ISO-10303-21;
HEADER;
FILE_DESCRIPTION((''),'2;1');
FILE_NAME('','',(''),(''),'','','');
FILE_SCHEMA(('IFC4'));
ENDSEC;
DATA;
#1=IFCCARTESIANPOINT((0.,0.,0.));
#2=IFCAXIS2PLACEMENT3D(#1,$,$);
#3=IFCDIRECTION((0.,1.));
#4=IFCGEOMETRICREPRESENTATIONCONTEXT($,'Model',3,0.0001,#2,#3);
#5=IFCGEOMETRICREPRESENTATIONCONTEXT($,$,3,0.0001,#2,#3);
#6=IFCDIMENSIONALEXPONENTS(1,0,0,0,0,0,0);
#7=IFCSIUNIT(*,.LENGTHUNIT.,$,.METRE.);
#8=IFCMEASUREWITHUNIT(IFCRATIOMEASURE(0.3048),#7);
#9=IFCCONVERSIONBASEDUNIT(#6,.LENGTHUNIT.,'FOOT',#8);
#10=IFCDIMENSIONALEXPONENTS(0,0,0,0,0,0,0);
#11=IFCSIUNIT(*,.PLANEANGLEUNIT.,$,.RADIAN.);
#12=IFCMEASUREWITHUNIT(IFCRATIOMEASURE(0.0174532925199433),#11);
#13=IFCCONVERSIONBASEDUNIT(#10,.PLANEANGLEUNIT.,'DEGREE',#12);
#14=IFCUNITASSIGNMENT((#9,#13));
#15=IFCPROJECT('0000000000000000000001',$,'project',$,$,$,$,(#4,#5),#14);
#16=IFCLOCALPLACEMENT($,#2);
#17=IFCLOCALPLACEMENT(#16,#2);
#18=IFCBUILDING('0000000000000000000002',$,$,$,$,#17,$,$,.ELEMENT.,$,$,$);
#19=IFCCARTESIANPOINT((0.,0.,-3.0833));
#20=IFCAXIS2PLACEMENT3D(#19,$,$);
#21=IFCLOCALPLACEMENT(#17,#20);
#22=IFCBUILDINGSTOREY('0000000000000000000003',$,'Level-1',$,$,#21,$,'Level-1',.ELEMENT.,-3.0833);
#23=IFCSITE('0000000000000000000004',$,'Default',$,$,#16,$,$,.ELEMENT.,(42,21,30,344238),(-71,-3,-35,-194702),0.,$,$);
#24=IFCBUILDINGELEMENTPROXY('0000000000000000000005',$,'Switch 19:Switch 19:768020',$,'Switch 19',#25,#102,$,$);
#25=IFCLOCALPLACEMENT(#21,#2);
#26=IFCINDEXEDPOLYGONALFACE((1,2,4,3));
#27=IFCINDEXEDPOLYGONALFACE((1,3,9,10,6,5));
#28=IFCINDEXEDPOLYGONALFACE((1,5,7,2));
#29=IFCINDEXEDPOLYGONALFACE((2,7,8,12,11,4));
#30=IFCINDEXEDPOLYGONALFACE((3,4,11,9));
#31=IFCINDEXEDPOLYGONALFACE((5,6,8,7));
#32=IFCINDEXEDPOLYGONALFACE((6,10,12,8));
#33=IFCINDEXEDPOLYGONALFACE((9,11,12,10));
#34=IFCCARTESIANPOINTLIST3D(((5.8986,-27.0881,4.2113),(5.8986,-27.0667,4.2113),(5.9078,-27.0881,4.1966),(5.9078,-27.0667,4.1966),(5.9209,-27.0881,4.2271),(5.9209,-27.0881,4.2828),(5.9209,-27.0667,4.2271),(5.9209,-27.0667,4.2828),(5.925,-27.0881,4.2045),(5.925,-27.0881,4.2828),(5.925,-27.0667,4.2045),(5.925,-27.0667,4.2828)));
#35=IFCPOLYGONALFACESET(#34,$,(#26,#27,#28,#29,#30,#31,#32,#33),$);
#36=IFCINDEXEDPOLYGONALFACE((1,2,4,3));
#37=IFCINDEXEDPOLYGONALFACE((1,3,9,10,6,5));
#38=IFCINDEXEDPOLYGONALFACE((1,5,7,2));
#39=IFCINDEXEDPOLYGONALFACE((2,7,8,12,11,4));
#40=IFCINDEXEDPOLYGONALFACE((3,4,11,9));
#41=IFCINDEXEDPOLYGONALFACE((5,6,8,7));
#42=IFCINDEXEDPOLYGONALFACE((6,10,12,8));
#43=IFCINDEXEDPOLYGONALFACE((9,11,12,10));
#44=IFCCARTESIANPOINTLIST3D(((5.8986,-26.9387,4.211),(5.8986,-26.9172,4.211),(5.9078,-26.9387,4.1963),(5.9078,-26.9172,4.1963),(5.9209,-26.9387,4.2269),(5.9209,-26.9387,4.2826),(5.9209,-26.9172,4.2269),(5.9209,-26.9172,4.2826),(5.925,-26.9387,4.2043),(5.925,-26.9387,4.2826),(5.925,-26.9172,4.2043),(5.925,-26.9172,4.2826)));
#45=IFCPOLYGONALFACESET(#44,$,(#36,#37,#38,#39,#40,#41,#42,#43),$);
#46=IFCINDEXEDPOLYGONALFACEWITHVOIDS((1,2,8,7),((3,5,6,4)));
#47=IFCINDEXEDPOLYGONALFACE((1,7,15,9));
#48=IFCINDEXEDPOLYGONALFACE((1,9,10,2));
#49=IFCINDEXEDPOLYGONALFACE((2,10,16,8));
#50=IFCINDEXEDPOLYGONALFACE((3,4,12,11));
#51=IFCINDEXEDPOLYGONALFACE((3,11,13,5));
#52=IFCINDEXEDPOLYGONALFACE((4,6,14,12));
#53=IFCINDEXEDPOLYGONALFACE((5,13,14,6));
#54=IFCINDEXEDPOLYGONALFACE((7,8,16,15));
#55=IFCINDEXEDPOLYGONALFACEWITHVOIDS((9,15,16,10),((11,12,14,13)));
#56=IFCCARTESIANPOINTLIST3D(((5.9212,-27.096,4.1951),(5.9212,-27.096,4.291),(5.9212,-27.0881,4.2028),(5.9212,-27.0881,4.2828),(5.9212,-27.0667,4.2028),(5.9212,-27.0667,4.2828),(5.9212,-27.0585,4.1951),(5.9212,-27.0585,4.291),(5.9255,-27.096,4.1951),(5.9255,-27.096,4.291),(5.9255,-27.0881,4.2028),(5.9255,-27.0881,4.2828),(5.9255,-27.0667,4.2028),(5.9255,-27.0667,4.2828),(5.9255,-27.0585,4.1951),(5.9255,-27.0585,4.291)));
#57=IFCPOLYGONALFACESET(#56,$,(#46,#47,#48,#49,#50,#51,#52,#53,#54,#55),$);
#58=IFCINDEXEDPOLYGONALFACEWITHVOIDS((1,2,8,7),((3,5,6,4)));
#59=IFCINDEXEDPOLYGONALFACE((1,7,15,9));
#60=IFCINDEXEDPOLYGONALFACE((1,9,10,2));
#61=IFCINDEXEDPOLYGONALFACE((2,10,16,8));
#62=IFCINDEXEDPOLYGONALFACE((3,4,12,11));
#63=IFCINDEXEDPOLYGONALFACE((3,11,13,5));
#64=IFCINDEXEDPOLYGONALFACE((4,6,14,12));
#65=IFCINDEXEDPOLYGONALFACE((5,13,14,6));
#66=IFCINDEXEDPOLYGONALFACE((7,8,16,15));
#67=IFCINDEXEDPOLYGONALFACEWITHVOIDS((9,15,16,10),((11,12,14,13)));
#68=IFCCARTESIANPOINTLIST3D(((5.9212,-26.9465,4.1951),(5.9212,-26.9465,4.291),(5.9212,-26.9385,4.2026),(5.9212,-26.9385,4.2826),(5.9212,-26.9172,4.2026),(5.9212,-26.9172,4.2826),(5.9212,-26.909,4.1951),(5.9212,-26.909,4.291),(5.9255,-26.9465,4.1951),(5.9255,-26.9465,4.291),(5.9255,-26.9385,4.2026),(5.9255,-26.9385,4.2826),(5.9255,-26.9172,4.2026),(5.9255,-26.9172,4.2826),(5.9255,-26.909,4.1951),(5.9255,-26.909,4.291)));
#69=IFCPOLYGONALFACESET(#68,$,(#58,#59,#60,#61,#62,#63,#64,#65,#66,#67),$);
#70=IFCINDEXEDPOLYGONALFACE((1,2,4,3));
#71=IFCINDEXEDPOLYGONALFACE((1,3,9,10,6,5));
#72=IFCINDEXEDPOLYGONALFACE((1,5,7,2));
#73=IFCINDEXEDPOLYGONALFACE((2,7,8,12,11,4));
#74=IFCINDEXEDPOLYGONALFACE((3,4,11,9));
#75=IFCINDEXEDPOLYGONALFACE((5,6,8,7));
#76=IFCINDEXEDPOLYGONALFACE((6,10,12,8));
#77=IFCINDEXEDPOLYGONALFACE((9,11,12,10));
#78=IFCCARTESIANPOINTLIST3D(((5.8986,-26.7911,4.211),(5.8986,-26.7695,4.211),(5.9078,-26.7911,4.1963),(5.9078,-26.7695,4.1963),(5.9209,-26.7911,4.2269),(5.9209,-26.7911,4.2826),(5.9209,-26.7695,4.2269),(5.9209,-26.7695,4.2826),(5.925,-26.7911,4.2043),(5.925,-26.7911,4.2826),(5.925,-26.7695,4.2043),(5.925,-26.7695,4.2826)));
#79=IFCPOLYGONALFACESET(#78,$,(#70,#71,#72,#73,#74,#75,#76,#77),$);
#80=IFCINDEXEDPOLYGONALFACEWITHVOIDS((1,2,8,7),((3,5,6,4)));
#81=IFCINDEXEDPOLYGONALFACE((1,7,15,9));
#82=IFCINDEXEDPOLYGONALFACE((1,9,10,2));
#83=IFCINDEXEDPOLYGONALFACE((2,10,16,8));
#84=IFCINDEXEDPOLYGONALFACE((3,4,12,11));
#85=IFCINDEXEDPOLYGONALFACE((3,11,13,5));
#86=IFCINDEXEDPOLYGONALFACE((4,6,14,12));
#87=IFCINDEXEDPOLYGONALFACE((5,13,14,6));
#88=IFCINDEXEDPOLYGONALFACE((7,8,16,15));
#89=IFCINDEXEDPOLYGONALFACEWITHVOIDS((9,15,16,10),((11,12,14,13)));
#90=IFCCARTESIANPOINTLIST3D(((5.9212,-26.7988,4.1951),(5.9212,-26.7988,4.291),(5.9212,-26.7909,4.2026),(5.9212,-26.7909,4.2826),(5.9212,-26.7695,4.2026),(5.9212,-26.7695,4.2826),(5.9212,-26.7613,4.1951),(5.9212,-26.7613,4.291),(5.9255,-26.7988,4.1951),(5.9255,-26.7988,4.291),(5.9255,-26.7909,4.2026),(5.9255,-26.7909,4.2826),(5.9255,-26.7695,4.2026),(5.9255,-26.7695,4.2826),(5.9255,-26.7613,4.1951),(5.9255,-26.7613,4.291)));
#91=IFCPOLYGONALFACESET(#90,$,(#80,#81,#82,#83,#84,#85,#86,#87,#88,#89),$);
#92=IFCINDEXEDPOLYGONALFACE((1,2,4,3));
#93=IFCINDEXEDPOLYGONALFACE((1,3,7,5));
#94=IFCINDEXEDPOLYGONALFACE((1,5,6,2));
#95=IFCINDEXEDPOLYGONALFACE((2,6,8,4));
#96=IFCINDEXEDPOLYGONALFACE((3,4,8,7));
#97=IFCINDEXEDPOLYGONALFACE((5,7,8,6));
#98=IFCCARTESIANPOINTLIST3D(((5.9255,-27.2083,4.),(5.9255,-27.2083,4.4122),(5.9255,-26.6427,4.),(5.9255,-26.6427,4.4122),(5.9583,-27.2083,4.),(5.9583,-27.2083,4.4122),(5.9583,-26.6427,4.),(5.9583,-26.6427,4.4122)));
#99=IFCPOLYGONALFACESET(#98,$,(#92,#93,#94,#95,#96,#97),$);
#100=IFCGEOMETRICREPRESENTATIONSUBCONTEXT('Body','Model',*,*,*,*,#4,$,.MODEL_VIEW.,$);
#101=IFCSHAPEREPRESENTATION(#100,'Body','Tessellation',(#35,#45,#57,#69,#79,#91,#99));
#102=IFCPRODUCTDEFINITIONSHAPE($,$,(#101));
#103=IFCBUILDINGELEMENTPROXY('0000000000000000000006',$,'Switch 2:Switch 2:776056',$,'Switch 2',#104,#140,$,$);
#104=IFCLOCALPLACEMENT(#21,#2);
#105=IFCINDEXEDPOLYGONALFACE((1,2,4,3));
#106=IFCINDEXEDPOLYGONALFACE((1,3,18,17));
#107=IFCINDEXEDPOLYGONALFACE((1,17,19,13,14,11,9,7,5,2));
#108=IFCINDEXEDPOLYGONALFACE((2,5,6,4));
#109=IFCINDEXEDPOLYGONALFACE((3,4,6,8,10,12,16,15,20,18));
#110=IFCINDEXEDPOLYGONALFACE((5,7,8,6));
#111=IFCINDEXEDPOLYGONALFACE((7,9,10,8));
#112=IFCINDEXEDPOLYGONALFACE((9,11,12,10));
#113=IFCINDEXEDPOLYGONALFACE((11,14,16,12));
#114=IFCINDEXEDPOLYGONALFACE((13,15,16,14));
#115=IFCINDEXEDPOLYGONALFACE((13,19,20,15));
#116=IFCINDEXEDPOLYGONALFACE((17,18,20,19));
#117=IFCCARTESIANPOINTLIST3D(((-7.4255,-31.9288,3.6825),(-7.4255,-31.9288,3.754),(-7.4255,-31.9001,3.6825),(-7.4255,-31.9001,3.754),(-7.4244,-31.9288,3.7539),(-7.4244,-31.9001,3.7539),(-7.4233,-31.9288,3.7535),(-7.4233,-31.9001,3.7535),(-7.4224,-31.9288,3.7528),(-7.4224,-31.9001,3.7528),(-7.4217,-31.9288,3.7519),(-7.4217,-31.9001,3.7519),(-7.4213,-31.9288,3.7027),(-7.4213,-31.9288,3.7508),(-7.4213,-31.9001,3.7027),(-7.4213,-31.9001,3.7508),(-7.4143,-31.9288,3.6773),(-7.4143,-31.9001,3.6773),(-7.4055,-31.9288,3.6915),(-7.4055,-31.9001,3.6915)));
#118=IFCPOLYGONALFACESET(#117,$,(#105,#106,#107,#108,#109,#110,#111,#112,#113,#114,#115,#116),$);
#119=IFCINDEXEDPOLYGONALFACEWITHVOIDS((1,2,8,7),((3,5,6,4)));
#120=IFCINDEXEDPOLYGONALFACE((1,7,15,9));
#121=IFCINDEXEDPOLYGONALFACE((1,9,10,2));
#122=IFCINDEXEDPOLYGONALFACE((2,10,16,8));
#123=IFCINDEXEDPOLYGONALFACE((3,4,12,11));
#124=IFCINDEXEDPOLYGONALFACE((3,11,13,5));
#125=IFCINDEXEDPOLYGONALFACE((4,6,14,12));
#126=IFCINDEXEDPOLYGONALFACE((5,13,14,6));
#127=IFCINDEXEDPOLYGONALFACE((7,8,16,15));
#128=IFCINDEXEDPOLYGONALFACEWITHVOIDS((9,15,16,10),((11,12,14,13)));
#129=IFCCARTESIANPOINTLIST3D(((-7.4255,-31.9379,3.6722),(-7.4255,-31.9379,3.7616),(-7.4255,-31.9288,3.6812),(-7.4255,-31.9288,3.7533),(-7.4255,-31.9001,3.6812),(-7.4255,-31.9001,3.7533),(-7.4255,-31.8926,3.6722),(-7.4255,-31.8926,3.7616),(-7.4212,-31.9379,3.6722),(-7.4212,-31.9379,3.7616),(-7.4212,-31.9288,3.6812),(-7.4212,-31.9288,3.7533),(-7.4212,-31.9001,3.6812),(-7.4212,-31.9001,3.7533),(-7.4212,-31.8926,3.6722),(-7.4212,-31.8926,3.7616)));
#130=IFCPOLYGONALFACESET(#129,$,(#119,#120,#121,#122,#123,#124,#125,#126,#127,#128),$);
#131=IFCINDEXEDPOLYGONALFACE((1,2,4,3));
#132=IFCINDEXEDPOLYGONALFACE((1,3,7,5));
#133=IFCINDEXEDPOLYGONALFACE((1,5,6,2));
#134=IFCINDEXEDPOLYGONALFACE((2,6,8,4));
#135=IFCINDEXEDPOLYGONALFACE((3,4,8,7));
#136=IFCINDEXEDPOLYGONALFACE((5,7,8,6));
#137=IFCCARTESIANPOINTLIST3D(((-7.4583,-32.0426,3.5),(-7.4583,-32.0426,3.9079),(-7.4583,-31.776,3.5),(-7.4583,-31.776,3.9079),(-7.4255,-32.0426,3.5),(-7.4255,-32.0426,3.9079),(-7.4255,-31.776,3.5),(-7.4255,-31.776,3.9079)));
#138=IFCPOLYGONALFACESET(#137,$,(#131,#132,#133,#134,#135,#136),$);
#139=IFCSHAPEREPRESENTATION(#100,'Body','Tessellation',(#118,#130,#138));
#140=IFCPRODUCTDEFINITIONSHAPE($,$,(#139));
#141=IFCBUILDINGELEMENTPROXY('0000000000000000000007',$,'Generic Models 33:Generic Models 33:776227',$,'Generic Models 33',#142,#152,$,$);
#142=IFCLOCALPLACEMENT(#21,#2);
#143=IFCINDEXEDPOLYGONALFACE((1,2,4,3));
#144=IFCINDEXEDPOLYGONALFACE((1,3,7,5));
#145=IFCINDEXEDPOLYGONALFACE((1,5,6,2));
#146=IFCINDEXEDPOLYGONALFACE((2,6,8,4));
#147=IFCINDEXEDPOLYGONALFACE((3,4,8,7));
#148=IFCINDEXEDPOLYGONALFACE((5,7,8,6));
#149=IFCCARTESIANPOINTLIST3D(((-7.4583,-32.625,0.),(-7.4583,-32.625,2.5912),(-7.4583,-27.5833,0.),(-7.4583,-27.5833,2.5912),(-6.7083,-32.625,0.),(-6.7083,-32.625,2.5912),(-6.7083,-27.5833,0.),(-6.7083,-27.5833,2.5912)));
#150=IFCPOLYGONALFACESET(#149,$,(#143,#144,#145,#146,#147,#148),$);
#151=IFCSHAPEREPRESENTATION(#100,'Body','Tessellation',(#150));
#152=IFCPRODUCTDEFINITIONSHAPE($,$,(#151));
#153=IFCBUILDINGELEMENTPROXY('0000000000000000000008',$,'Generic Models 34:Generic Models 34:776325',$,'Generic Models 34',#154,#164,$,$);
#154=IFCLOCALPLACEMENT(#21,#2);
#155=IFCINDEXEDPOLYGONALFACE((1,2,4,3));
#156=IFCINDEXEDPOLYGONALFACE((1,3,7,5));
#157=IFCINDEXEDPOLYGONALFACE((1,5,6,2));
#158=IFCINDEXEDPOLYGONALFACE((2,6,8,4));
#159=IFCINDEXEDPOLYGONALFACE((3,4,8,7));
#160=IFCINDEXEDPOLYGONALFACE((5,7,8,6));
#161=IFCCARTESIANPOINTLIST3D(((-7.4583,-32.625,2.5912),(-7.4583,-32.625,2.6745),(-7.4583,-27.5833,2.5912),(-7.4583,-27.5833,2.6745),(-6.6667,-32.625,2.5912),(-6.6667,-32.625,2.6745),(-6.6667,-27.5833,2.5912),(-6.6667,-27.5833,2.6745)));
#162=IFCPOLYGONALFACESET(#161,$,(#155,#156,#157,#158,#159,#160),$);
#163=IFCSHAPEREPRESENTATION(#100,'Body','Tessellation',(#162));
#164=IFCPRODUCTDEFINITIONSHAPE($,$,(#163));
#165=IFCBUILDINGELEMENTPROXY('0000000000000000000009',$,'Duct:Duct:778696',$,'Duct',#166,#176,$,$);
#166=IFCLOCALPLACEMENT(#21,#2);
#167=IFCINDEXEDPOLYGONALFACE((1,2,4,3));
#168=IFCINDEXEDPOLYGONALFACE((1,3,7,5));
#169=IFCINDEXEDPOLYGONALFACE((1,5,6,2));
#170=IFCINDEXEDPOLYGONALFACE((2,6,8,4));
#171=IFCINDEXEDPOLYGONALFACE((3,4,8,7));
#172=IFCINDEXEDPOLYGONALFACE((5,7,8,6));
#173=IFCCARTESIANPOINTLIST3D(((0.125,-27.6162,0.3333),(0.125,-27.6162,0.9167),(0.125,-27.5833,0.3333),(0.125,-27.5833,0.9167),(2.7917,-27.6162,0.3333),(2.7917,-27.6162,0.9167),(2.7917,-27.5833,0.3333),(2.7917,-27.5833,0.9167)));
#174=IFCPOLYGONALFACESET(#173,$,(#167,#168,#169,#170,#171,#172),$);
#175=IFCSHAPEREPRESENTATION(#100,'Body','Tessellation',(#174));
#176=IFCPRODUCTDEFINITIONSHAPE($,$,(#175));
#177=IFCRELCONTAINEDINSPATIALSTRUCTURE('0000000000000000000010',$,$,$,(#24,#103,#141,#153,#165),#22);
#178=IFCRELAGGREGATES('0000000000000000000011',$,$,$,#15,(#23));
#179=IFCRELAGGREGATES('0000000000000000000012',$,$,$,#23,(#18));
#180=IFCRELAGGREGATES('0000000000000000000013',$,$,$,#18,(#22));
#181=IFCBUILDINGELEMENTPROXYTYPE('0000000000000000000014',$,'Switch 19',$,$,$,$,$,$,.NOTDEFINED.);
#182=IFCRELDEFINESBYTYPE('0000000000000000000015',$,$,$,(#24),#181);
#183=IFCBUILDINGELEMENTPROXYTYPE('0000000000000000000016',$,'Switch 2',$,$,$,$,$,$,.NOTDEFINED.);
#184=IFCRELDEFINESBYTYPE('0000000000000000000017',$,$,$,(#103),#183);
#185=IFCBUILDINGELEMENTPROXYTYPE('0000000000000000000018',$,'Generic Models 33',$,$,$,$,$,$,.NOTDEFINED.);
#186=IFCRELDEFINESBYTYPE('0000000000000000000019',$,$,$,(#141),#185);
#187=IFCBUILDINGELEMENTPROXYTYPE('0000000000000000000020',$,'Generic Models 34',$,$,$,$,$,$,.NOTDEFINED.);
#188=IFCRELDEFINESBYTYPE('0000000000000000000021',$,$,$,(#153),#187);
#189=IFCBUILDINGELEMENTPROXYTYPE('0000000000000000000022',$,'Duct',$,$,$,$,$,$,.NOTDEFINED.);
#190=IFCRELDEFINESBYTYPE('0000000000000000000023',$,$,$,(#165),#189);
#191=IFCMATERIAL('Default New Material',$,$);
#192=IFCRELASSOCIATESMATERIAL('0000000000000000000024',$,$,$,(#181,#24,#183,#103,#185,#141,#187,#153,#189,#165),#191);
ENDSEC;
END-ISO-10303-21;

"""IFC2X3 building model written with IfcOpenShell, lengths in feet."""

from ifc_helpers import new_model, entity, si_unit, converted_unit, direction, frame, frame_2d, origin, origin_2d_with_axis, place, context, subcontext, project, spatial, polyline, circle_curve, parameter, trimmed, segment, composite_curve, rectangle, outline, extrude, source, transform, mapped, material, type_object, type_shapes, element, save


model = new_model("IFC2X3")

# Units and contexts
model_context = context("Model", 3, precision=0.0001, world=origin(), true_north=direction((0.0, 1.0)))
context_of_model = context(None, 3, precision=0.0001, world=origin(), true_north=direction((0.0, 1.0)))
body_context = subcontext(model_context, "Body", "Model", "MODEL_VIEW")
ifc_project = project(units=[converted_unit("LENGTHUNIT", "FOOT", entity("IfcRatioMeasure", 0.3048), si_unit("LENGTHUNIT", "METRE"), dimensions=[1, 0, 0, 0, 0, 0, 0]), converted_unit("PLANEANGLEUNIT", "DEGREE", entity("IfcRatioMeasure", 0.0174532925199433), si_unit("PLANEANGLEUNIT", "RADIAN"), dimensions=[0, 0, 0, 0, 0, 0, 0])], contexts=[model_context, context_of_model])

# Site, building, storey
site_placement = place(None, origin())
site = spatial("IfcSite", under=ifc_project, at=site_placement, Name="Default", CompositionType="ELEMENT", RefLatitude=(42, 21, 30, 344238), RefLongitude=(-71, -3, -35, -194702), RefElevation=0.0)
building_placement = place(site_placement, origin())
building = spatial("IfcBuilding", under=site, at=building_placement, CompositionType="ELEMENT")
storey_placement = place(building_placement, frame((0.0, 0.0, -3.0833)))
storey = spatial("IfcBuildingStorey", under=building, at=storey_placement, Name="Level-1", LongName="Level-1", CompositionType="ELEMENT", Elevation=-3.0833)

# Shared definitions
ifc_material_1 = material(Name="Default New Material")

# Building element proxies
building_element_proxy_type_1 = type_object("IfcBuildingElementProxyType", Name="Switch 19", PredefinedType="NOTDEFINED", material=ifc_material_1)
shared_shape_1 = source(origin(), body_context, "Body", "SweptSolid", [
    extrude(outline(polyline([(-0.0236, -0.0305), (-0.0047, -0.0305), (0.0283, 0.0405), (0.0246, 0.0422), (0.0011, -0.0083), (-0.0257, -0.0133), (-0.0236, -0.0305)])), frame((0.1412, -0.042, 0.2342), z_axis=(1.0, 0.0, 0.0), x_axis=(0.0, 0.906882, 0.421385)), (0.0, 0.0, 1.0), 0.0214),
    extrude(outline(polyline([(-0.0236, -0.0305), (-0.0047, -0.0305), (0.0283, 0.0405), (0.0246, 0.0422), (0.0011, -0.0083), (-0.0257, -0.0133), (-0.0236, -0.0305)])), frame((-0.0084, -0.042, 0.234), z_axis=(1.0, 0.0, 0.0), x_axis=(0.0, 0.906882, 0.421385)), (0.0, 0.0, 1.0), 0.0216),
    extrude(outline(polyline([(-0.0187, -0.048), (0.0187, -0.048), (0.0187, 0.048), (-0.0187, 0.048), (-0.0187, -0.048)]), holes=[polyline([(-0.0108, -0.0402), (-0.0108, 0.0397), (0.0106, 0.0397), (0.0106, -0.0402), (-0.0108, -0.0402)])]), frame((0.1518, -0.0371, 0.243), z_axis=(0.0, 1.0, 0.0), x_axis=(-1.0, 0.0, 0.0)), (0.0, 0.0, 1.0), 0.0042),
    extrude(outline(polyline([(-0.048, -0.0187), (0.048, -0.0187), (0.048, 0.0187), (-0.048, 0.0187), (-0.048, -0.0187)]), holes=[polyline([(-0.0395, -0.0108), (-0.0395, 0.0106), (0.0404, 0.0106), (0.0404, -0.0108), (-0.0395, -0.0108)])]), frame((0.0022, -0.0371, 0.243), z_axis=(0.0, 1.0, 0.0), x_axis=(0.0, 0.0, -1.0)), (0.0, 0.0, 1.0), 0.0042),
    extrude(outline(polyline([(-0.0236, -0.0305), (-0.0047, -0.0305), (0.0283, 0.0405), (0.0246, 0.0422), (0.0011, -0.0083), (-0.0257, -0.0133), (-0.0236, -0.0305)])), frame((-0.156, -0.042, 0.234), z_axis=(1.0, 0.0, 0.0), x_axis=(0.0, 0.906882, 0.421385)), (0.0, 0.0, 1.0), 0.0216),
    extrude(outline(polyline([(-0.048, -0.0187), (0.048, -0.0187), (0.048, 0.0187), (-0.048, 0.0187), (-0.048, -0.0187)]), holes=[polyline([(-0.0395, -0.0108), (-0.0395, 0.0106), (0.0404, 0.0106), (0.0404, -0.0108), (-0.0395, -0.0108)])]), frame((-0.1454, -0.0371, 0.243), z_axis=(0.0, 1.0, 0.0), x_axis=(0.0, 0.0, -1.0)), (0.0, 0.0, 1.0), 0.0042),
    extrude(rectangle(XDim=0.5656, YDim=0.0329, at=frame_2d((0.0, 0.0), x_axis=(1.0, 0.0))), frame((0.0, -0.0164, 0.0)), (0.0, 0.0, 1.0), 0.4122),
])
type_shapes(building_element_proxy_type_1, [shared_shape_1])
proxy_1_placement = place(storey_placement, frame((5.9583, -26.9255, 4.0), z_axis=(0.0, 0.0, 1.0), x_axis=(0.0, -1.0, 0.0)))
element("IfcBuildingElementProxy", 1, at=proxy_1_placement, inside=storey, type_object=building_element_proxy_type_1, material=ifc_material_1, Name="Switch 19:Switch 19:768020", ObjectType="Switch 19", context=body_context, shape_type="MappedRepresentation", body=[
    mapped(shared_shape_1, transform((0.0, 0.0, 0.0), scale=1.0)),
])
building_element_proxy_type_2 = type_object("IfcBuildingElementProxyType", Name="Switch 2", PredefinedType="NOTDEFINED", material=ifc_material_1)
shared_shape_2 = source(origin(), body_context, "Body", "SweptSolid", [
    extrude(outline(composite_curve([segment(polyline([(-0.0252, -0.0211), (-0.0084, -0.0211)]), True, "CONTINUOUS"), segment(polyline([(-0.0084, -0.0211), (-0.0073, -0.0017)]), True, "CONTINUOUS"), segment(polyline([(-0.0073, -0.0017), (0.0336, 0.0237)]), True, "CONTINUOUS"), segment(trimmed(circle_curve(frame_2d((0.0308, 0.0266), x_axis=(0.848706, 0.528865)), 0.004), [parameter(281.689503)], [parameter(4.471238)], True, "PARAMETER"), True, "CONTINUOUS"), segment(polyline([(0.034, 0.029), (-0.0267, -0.0088)]), True, "CONTINUOUS"), segment(polyline([(-0.0267, -0.0088), (-0.0252, -0.0211)]), True, "CONTINUOUS")], self_intersect=False)), frame((-0.0093, 0.0394, 0.2098), z_axis=(1.0, 0.0, 0.0), x_axis=(0.0, 0.528865, 0.848706)), (0.0, 0.0, 1.0), 0.0287),
    extrude(outline(polyline([(-0.0447, -0.0227), (0.0447, -0.0227), (0.0447, 0.0227), (-0.0447, 0.0227), (-0.0447, -0.0227)]), holes=[polyline([(-0.0364, -0.0136), (-0.0364, 0.0151), (0.0357, 0.0151), (0.0357, -0.0136), (-0.0364, -0.0136)])]), frame((0.0058, 0.0329, 0.2169), z_axis=(0.0, 1.0, 0.0), x_axis=(0.0, 0.0, -1.0)), (0.0, 0.0, 1.0), 0.0042),
    extrude(rectangle(XDim=0.0329, YDim=0.2666, at=origin_2d_with_axis()), frame((-0.0001, 0.0164, 0.0), z_axis=(0.0, 0.0, 1.0), x_axis=(0.0, -1.0, 0.0)), (0.0, 0.0, 1.0), 0.4079),
])
type_shapes(building_element_proxy_type_2, [shared_shape_2])
proxy_2_placement = place(storey_placement, frame((-7.4583, -31.9094, 3.5), z_axis=(0.0, 0.0, 1.0), x_axis=(0.0, -1.0, 0.0)))
element("IfcBuildingElementProxy", 2, at=proxy_2_placement, inside=storey, type_object=building_element_proxy_type_2, material=ifc_material_1, Name="Switch 2:Switch 2:776056", ObjectType="Switch 2", context=body_context, shape_type="MappedRepresentation", body=[
    mapped(shared_shape_2, transform((0.0, 0.0, 0.0), scale=1.0)),
])
building_element_proxy_type_3 = type_object("IfcBuildingElementProxyType", Name="Generic Models 33", PredefinedType="NOTDEFINED", material=ifc_material_1)
shared_shape_3 = source(origin(), body_context, "Body", "SweptSolid", [
    extrude(rectangle(XDim=0.75, YDim=5.0417, at=frame_2d((0.0, 0.0), x_axis=(1.0, 0.0))), frame((0.375, 2.5208, 0.0), z_axis=(0.0, 0.0, 1.0), x_axis=(-1.0, 0.0, 0.0)), (0.0, 0.0, 1.0), 2.5912),
])
type_shapes(building_element_proxy_type_3, [shared_shape_3])
proxy_3_placement = place(storey_placement, frame((-7.4583, -32.625, 0.0)))
element("IfcBuildingElementProxy", 3, at=proxy_3_placement, inside=storey, type_object=building_element_proxy_type_3, material=ifc_material_1, Name="Generic Models 33:Generic Models 33:776227", ObjectType="Generic Models 33", context=body_context, shape_type="MappedRepresentation", body=[
    mapped(shared_shape_3, transform((0.0, 0.0, 0.0), scale=1.0)),
])
building_element_proxy_type_4 = type_object("IfcBuildingElementProxyType", Name="Generic Models 34", PredefinedType="NOTDEFINED", material=ifc_material_1)
shared_shape_4 = source(origin(), body_context, "Body", "SweptSolid", [
    extrude(rectangle(XDim=0.7917, YDim=5.0417, at=frame_2d((0.0, 0.0), x_axis=(1.0, 0.0))), frame((0.3958, 2.5208, 0.0), z_axis=(0.0, 0.0, 1.0), x_axis=(-1.0, 0.0, 0.0)), (0.0, 0.0, 1.0), 0.0833),
])
type_shapes(building_element_proxy_type_4, [shared_shape_4])
proxy_4_placement = place(storey_placement, frame((-7.4583, -32.625, 2.5912)))
element("IfcBuildingElementProxy", 4, at=proxy_4_placement, inside=storey, type_object=building_element_proxy_type_4, material=ifc_material_1, Name="Generic Models 34:Generic Models 34:776325", ObjectType="Generic Models 34", context=body_context, shape_type="MappedRepresentation", body=[
    mapped(shared_shape_4, transform((0.0, 0.0, 0.0), scale=1.0)),
])
building_element_proxy_type_5 = type_object("IfcBuildingElementProxyType", Name="Duct", PredefinedType="NOTDEFINED", material=ifc_material_1)
shared_shape_5 = source(origin(), body_context, "Body", "SweptSolid", [
    extrude(rectangle(XDim=0.0329, YDim=2.6667, at=origin_2d_with_axis()), frame((1.2025, -0.0164, 0.0), z_axis=(0.0, 0.0, 1.0), x_axis=(0.0, 1.0, 0.0)), (0.0, 0.0, 1.0), 0.5833),
])
type_shapes(building_element_proxy_type_5, [shared_shape_5])
proxy_5_placement = place(storey_placement, frame((0.2559, -27.5833, 0.3333)))
element("IfcBuildingElementProxy", 5, at=proxy_5_placement, inside=storey, type_object=building_element_proxy_type_5, material=ifc_material_1, Name="Duct:Duct:778696", ObjectType="Duct", context=body_context, shape_type="MappedRepresentation", body=[
    mapped(shared_shape_5, transform((0.0, 0.0, 0.0), scale=1.0)),
])

save(model, "model.ifc")
